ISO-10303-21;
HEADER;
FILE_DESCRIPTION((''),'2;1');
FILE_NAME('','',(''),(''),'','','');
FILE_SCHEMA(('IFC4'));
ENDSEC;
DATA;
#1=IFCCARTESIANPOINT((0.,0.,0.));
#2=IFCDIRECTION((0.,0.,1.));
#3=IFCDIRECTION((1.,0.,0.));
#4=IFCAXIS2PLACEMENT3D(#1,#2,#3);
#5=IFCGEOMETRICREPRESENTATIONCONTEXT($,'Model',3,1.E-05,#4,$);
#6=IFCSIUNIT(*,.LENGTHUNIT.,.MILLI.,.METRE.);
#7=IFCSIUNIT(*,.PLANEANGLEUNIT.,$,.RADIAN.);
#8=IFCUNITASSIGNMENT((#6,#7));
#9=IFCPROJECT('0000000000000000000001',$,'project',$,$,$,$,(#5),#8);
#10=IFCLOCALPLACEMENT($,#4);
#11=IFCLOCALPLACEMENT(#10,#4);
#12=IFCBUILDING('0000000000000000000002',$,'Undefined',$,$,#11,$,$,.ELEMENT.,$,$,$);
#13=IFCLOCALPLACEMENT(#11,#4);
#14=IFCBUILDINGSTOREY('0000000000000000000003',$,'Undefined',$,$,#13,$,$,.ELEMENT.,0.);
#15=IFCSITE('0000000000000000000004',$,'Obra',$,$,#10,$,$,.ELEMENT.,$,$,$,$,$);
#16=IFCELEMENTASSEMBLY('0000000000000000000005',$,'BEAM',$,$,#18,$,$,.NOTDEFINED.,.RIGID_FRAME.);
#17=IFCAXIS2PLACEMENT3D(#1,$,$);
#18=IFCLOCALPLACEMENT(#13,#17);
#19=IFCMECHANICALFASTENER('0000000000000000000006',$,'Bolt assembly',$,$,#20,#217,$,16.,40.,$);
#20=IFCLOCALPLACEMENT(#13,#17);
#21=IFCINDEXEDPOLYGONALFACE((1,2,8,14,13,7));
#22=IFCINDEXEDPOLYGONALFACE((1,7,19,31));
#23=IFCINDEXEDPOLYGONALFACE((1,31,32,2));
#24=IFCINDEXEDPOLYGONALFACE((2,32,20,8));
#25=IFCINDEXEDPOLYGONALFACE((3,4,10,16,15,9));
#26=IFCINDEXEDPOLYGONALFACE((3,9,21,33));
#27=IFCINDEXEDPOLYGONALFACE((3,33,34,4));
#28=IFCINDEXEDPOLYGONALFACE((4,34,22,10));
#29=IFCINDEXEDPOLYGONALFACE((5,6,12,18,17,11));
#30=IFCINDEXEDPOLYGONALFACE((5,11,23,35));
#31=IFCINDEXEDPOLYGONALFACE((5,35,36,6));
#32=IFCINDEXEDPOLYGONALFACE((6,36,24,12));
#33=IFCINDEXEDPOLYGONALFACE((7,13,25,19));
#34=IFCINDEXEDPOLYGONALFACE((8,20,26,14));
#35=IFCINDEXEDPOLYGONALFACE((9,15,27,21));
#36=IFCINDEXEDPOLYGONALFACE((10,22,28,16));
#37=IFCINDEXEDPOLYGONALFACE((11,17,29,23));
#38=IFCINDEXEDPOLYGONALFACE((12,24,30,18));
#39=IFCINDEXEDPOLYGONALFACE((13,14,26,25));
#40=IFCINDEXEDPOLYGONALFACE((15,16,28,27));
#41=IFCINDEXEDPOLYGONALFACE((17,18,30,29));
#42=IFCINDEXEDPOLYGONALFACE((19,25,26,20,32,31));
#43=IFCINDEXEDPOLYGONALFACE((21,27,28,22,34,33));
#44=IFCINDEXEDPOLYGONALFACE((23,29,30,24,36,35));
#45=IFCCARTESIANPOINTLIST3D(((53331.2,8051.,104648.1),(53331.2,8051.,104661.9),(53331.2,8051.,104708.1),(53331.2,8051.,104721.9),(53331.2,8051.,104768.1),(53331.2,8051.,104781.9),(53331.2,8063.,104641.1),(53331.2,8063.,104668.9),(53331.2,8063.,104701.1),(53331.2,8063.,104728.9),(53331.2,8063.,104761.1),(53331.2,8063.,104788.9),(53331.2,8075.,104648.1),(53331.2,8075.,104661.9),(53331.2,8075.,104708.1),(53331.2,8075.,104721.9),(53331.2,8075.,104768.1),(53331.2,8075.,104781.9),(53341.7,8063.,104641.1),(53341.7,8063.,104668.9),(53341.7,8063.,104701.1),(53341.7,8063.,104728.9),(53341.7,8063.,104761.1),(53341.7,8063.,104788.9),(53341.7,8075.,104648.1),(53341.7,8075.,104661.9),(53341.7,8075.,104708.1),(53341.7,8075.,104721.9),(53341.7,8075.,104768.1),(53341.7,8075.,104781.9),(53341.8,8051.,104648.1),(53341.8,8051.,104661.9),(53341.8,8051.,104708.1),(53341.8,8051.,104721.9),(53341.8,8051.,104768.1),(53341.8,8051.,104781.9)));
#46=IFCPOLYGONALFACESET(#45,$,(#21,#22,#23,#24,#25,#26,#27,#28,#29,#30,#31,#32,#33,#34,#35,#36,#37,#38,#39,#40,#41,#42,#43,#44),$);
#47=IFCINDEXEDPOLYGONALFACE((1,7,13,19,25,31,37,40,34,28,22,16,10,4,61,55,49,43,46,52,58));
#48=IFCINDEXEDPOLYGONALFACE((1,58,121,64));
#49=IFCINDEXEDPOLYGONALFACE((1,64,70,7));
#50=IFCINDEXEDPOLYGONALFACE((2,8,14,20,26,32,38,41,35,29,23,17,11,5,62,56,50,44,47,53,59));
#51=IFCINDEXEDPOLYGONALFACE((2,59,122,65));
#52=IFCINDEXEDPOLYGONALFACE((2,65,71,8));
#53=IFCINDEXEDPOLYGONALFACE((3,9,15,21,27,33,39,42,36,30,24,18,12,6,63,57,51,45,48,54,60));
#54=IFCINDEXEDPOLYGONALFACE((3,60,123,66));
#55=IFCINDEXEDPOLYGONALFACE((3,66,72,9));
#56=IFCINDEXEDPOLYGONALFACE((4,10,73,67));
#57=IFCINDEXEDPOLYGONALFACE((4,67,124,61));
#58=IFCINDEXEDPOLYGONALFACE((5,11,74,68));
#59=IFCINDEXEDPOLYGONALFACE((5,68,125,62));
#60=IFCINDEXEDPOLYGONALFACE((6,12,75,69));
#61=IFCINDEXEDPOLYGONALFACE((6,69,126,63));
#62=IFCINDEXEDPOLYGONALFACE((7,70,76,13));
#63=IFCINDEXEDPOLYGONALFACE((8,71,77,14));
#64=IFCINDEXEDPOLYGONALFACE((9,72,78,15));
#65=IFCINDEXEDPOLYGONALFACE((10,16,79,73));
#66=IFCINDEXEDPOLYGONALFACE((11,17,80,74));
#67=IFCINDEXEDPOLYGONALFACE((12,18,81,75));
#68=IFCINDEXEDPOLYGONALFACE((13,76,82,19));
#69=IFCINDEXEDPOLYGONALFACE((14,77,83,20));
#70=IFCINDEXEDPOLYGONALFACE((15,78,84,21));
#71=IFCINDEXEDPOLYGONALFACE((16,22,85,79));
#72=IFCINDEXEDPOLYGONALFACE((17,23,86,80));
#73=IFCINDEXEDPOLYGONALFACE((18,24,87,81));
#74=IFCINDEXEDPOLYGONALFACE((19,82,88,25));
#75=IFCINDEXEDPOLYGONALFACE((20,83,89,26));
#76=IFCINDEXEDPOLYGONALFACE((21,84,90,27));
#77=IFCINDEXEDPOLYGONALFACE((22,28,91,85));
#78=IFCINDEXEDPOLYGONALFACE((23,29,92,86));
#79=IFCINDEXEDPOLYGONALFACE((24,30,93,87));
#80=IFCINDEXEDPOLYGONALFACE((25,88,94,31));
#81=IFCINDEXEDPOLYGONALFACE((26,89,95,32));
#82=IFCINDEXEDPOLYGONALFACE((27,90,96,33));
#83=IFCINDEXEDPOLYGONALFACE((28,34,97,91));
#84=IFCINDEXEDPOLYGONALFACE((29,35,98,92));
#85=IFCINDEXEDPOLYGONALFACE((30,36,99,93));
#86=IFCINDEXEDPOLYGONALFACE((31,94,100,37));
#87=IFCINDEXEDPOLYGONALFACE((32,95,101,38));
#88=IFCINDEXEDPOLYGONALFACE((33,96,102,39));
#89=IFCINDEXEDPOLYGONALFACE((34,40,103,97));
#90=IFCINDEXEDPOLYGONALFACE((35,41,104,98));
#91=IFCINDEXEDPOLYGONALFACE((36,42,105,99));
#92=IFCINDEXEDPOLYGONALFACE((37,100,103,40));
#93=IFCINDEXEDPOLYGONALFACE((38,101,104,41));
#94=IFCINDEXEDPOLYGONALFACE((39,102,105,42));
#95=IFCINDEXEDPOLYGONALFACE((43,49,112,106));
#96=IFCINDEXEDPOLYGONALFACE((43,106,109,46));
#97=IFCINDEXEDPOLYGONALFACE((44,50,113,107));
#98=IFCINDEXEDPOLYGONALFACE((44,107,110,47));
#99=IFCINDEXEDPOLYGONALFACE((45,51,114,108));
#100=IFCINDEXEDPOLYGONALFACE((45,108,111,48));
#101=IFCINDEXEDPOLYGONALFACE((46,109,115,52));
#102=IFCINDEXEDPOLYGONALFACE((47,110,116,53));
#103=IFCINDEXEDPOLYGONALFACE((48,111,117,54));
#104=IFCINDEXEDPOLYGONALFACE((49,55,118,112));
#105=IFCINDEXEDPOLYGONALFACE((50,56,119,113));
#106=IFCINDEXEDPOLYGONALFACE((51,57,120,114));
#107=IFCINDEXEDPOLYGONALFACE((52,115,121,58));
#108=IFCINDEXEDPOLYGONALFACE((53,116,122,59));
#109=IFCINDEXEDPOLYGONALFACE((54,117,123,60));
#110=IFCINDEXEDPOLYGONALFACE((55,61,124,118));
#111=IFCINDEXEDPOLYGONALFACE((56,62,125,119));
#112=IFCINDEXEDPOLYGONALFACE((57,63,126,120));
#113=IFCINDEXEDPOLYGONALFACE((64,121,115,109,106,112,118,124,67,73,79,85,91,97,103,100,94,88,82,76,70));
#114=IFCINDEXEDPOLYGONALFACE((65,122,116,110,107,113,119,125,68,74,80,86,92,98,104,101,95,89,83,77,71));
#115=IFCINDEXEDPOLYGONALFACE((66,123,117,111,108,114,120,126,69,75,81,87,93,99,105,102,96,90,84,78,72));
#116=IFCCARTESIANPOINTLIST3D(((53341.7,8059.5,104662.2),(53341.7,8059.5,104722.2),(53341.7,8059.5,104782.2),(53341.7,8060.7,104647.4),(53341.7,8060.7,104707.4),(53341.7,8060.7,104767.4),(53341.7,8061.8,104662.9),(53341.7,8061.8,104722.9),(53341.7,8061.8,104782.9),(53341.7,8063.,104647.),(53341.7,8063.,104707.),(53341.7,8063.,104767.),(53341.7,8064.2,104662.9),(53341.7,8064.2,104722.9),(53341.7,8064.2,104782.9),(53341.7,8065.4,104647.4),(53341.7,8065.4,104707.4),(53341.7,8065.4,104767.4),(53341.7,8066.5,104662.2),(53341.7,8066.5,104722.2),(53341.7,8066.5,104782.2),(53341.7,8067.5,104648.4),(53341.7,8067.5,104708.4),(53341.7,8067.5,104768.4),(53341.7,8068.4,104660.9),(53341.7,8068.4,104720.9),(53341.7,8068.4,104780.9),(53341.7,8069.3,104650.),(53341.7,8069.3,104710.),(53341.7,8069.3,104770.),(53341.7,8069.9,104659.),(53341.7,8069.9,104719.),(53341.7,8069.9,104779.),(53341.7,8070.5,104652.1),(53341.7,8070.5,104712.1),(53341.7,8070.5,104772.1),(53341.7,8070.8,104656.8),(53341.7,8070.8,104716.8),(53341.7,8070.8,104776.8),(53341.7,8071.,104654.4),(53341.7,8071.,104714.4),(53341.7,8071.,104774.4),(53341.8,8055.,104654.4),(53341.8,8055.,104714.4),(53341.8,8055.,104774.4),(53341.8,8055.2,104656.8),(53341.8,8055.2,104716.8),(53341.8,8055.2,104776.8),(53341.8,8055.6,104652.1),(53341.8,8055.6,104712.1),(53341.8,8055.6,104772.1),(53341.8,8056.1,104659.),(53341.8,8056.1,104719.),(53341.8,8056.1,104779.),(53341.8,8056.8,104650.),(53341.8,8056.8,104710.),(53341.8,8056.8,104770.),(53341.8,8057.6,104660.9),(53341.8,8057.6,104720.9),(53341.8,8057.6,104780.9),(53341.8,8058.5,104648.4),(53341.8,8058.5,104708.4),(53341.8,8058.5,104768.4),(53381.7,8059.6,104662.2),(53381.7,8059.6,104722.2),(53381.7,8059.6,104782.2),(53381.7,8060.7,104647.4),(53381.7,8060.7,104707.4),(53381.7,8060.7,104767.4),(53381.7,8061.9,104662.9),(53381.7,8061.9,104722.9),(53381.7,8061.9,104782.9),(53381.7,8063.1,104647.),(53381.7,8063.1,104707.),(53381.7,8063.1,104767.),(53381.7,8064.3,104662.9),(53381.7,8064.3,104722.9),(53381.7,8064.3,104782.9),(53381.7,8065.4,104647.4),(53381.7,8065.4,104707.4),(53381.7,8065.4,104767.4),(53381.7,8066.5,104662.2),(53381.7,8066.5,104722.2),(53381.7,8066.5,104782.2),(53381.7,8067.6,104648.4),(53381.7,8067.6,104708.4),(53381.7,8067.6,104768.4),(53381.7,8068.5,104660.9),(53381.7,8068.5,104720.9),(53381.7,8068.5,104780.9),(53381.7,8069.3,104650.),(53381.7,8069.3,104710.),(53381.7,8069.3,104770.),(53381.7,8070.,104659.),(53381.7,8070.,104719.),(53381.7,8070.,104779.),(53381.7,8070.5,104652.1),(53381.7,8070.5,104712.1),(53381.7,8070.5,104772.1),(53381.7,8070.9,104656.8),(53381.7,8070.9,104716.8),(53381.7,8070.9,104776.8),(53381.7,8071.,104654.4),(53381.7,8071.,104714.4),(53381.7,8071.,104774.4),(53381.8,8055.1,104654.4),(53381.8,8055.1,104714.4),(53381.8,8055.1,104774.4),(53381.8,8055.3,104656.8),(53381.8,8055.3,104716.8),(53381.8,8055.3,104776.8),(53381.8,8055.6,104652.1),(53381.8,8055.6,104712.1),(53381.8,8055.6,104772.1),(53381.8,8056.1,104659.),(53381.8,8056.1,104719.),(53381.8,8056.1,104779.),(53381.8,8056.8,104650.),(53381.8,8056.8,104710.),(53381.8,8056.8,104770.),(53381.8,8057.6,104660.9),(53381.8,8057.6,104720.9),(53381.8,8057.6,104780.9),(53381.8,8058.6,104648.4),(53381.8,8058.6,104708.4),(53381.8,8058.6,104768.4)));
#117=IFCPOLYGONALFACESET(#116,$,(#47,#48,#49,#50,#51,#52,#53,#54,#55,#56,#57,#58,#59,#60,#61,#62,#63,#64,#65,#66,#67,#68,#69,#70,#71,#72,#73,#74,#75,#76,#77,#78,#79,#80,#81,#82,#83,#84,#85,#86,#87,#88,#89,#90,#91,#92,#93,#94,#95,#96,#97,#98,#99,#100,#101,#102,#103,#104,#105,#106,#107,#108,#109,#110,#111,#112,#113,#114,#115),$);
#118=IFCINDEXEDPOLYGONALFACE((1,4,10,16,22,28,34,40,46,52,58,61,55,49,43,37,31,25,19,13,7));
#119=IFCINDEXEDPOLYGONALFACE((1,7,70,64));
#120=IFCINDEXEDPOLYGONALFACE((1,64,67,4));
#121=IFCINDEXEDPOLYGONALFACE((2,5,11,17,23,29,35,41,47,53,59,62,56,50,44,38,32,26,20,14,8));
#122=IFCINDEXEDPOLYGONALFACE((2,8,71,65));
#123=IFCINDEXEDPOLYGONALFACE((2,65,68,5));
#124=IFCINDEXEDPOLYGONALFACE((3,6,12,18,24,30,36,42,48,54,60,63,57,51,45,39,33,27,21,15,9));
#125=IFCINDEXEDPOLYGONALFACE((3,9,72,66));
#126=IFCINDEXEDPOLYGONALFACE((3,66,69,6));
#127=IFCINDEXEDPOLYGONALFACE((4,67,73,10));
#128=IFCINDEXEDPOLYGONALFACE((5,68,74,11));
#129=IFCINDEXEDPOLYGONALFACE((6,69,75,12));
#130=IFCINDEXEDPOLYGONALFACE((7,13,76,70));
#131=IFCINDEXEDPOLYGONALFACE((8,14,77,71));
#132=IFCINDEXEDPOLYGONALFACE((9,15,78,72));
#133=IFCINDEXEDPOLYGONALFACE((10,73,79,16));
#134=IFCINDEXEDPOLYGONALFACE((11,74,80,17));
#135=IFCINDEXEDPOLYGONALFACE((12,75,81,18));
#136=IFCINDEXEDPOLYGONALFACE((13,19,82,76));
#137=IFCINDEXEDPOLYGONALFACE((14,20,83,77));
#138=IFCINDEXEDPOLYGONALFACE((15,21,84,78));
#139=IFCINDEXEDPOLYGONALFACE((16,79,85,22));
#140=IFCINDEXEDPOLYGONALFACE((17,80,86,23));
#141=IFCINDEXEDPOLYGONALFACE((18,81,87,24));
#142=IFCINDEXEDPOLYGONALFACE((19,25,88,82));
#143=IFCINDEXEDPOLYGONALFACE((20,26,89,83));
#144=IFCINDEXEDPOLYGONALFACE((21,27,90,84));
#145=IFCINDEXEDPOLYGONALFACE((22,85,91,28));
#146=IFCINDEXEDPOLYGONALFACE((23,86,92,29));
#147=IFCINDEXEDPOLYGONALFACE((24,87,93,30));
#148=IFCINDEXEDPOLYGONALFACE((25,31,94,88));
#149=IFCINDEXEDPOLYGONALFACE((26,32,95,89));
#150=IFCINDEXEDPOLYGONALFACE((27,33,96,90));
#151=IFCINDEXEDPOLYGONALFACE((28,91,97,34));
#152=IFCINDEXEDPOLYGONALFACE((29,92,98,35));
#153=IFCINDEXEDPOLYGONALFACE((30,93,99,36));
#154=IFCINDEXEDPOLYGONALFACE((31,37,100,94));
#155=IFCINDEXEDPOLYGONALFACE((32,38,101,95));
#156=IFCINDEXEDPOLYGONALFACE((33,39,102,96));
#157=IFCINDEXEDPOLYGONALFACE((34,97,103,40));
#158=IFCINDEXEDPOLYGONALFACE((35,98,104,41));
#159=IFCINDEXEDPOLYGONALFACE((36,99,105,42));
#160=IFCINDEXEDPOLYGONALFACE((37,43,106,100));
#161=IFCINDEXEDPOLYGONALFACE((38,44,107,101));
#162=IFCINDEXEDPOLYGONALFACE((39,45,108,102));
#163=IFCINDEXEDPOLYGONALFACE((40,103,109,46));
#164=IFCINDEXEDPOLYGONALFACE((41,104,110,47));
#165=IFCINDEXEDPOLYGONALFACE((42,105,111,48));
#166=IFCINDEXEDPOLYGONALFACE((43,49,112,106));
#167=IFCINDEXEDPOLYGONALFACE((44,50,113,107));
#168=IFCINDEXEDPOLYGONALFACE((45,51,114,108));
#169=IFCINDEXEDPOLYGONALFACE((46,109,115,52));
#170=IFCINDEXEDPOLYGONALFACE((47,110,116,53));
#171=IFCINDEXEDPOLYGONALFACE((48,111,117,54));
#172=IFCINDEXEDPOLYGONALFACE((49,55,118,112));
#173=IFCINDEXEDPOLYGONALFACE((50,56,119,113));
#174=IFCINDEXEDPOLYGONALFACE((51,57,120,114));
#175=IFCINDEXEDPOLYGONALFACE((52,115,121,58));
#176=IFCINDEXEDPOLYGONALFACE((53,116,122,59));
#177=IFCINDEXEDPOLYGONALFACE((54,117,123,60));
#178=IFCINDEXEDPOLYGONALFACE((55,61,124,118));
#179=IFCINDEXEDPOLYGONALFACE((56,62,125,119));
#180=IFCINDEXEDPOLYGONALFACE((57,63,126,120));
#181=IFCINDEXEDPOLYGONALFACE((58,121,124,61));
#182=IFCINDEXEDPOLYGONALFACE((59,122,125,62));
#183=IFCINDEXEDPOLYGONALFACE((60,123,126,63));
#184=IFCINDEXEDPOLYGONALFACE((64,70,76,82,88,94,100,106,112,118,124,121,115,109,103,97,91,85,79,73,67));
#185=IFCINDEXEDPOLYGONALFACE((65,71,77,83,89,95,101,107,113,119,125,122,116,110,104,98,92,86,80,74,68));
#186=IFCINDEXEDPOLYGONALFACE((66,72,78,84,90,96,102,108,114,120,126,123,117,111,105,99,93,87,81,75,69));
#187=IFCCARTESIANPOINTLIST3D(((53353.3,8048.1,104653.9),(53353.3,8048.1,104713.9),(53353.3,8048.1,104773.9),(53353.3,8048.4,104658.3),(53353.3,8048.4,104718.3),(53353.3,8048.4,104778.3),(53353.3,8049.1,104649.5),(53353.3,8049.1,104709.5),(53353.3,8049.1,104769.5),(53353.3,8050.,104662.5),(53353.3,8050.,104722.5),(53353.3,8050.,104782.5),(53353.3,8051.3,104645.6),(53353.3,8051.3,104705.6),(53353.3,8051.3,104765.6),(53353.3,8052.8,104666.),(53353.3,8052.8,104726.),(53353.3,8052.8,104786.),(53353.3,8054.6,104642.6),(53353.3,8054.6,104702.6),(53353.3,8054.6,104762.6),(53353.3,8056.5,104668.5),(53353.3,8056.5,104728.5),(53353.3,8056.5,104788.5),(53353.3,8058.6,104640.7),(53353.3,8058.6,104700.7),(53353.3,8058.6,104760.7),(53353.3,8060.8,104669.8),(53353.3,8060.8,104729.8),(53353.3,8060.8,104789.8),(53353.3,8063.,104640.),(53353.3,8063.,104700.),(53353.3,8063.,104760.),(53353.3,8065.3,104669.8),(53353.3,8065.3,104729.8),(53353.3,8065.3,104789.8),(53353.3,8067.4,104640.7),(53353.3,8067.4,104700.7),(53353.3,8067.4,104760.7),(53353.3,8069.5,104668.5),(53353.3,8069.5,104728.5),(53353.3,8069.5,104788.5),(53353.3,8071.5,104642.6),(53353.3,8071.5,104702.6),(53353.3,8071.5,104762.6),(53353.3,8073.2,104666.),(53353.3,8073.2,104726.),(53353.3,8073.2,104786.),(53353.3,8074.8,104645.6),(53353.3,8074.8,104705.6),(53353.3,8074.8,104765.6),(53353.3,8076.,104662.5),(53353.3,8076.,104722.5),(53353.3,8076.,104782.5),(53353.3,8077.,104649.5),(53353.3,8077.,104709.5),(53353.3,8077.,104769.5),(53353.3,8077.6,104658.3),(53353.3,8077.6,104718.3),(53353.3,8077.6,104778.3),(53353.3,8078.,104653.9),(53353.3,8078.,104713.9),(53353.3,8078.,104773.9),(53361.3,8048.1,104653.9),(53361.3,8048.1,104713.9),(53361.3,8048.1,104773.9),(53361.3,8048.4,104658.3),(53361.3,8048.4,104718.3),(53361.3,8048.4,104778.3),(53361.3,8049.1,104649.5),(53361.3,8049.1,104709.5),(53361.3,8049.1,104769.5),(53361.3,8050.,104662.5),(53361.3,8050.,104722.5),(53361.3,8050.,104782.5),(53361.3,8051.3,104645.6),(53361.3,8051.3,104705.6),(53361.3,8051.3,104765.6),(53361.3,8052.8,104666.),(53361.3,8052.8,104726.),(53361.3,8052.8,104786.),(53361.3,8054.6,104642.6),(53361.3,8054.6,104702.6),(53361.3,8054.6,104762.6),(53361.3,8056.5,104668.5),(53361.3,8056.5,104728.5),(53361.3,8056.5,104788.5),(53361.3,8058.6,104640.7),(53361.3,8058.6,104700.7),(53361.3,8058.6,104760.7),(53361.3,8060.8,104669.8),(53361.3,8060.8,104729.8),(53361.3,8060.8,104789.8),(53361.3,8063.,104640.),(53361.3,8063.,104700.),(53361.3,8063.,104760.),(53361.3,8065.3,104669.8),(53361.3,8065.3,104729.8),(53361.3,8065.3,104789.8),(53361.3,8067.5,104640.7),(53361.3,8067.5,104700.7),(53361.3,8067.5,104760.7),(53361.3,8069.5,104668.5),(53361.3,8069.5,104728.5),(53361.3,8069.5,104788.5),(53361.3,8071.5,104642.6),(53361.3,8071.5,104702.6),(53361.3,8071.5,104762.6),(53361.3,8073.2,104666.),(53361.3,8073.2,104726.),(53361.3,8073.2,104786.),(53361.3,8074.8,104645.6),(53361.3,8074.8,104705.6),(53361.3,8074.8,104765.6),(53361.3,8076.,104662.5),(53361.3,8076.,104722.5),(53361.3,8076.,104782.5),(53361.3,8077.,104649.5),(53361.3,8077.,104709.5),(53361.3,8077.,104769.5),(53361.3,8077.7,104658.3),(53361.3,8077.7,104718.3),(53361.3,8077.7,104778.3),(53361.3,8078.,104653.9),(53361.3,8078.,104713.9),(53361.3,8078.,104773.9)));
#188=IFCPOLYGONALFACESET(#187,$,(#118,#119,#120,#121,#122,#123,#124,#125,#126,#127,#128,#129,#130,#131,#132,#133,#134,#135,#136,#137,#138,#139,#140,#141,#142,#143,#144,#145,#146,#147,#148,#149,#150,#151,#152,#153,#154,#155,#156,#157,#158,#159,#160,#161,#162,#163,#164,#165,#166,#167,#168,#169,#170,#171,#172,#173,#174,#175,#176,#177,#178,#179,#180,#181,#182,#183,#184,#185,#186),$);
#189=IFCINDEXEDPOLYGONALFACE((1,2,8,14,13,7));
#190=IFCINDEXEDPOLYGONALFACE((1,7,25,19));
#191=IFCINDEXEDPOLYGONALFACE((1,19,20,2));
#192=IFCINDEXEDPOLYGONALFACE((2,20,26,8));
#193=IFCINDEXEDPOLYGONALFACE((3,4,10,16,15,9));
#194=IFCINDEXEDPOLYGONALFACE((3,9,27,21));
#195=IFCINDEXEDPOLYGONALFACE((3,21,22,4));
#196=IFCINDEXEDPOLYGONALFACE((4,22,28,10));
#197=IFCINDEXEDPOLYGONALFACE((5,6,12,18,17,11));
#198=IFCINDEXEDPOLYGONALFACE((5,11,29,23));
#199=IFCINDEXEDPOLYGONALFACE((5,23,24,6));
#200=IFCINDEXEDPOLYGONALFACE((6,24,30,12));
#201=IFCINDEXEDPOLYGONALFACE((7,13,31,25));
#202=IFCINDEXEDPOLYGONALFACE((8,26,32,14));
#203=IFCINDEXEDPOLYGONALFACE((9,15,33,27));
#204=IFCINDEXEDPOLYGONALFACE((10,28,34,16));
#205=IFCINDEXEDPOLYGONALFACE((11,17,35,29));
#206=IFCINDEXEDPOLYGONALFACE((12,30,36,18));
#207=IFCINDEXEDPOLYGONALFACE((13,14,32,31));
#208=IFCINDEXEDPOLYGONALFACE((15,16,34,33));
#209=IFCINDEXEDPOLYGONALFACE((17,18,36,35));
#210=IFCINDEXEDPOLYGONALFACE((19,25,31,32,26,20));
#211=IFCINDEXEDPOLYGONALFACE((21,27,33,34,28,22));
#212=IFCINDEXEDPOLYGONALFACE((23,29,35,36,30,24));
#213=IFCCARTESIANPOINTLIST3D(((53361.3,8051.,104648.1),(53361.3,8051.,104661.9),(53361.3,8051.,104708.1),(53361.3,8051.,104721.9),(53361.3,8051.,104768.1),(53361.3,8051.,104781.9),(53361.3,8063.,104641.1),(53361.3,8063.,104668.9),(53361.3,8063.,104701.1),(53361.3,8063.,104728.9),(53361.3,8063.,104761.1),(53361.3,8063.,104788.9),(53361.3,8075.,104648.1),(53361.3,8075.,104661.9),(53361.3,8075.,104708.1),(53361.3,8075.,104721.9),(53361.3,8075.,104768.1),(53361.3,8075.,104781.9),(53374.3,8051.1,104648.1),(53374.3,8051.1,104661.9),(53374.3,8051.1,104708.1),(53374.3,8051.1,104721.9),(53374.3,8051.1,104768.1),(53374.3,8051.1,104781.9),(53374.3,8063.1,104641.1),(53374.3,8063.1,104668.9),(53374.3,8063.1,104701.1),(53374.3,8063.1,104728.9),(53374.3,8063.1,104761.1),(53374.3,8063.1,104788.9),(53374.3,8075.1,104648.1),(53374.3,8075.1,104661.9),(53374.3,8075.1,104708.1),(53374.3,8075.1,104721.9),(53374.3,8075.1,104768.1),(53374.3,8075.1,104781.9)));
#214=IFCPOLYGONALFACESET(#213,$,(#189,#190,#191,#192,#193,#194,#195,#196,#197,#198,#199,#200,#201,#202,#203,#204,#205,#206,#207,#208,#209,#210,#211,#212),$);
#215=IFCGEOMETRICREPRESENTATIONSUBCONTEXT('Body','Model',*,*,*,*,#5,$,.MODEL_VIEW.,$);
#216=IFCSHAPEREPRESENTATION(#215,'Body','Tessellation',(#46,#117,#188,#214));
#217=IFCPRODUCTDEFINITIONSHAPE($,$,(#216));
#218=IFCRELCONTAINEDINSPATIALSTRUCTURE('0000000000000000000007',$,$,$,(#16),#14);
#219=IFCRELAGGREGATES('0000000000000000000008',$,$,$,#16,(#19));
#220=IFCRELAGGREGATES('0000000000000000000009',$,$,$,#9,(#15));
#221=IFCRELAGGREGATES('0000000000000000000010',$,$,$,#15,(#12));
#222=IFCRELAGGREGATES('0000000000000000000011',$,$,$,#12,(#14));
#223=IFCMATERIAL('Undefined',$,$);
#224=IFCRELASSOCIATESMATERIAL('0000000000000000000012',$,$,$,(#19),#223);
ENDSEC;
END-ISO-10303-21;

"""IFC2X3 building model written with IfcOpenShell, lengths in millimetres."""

from ifc_helpers import new_model, si_unit, frame, origin_with_axes, origin_2d_with_axis, place, context, subcontext, project, spatial, polyline, circle, outline, extrude, source, transform, mapped, material, element, aggregate, save


model = new_model("IFC2X3")

# Units and contexts
model_context = context("Model", 3, precision=1e-05, world=origin_with_axes())
body_context = subcontext(model_context, "Body", "Model", "MODEL_VIEW")
ifc_project = project(units=[si_unit("LENGTHUNIT", "METRE", prefix="MILLI"), si_unit("PLANEANGLEUNIT", "RADIAN")], contexts=[model_context])

# Site, building, storey
site_placement = place(None, origin_with_axes())
site = spatial("IfcSite", under=ifc_project, at=site_placement, Name="Obra", CompositionType="ELEMENT")
building_placement = place(site_placement, origin_with_axes())
building = spatial("IfcBuilding", under=site, at=building_placement, Name="Undefined", CompositionType="ELEMENT")
storey_placement = place(building_placement, origin_with_axes())
storey = spatial("IfcBuildingStorey", under=building, at=storey_placement, Name="Undefined", CompositionType="ELEMENT", Elevation=0.0)

# Element assembly
ifc_material_1 = material(Name="Undefined")
assembly_1_placement = place(storey_placement, origin_with_axes())
assembly_1 = element("IfcElementAssembly", 1, at=assembly_1_placement, inside=storey, Name="BEAM", AssemblyPlace="NOTDEFINED", PredefinedType="RIGID_FRAME")

# Mechanical fastener
shared_shape_1 = source(origin_with_axes(), body_context, "Body", "SweptSolid", [
    extrude(outline(polyline([(13.9, 0.0), (6.9, 12.0), (-6.9, 12.0), (-13.9, 0.0), (-6.9, -12.0), (6.9, -12.0), (13.9, 0.0)])), frame((0.0, -19.7, 0.0), z_axis=(0.0, 1.0, 0.0), x_axis=(1.0, 0.0, 0.0)), (0.0, 0.0, 1.0), 10.6),
    extrude(circle(Radius=8.0, at=origin_2d_with_axis()), frame((0.0, -9.1, 0.0), z_axis=(0.0, 1.0, 0.0), x_axis=(1.0, 0.0, 0.0)), (0.0, 0.0, 1.0), 40.0),
    extrude(circle(Radius=15.0, at=origin_2d_with_axis()), frame((0.0, 2.5, 0.0), z_axis=(0.0, 1.0, 0.0), x_axis=(1.0, 0.0, 0.0)), (0.0, 0.0, 1.0), 8.0),
    extrude(outline(polyline([(13.9, 0.0), (6.9, 12.0), (-6.9, 12.0), (-13.9, 0.0), (-6.9, -12.0), (6.9, -12.0), (13.9, 0.0)])), frame((0.0, 10.5, 0.0), z_axis=(0.0, 1.0, 0.0), x_axis=(1.0, 0.0, 0.0)), (0.0, 0.0, 1.0), 13.0),
])
mechanical_fastener_1_placement = place(assembly_1_placement, frame((53350.8, 8113.0, 104835.0), z_axis=(0.001508, -0.999999, 0.0), x_axis=(0.0, 0.0, -1.0)))
mechanical_fastener_1 = element("IfcMechanicalFastener", 2, at=mechanical_fastener_1_placement, material=ifc_material_1, Name="Bolt assembly", NominalDiameter=16.0, NominalLength=40.0, context=body_context, shape_type="MappedRepresentation", body=[
    mapped(shared_shape_1, transform((60.0, 0.0, 50.0))),
    mapped(shared_shape_1, transform((120.0, 0.0, 50.0))),
    mapped(shared_shape_1, transform((180.0, 0.0, 50.0))),
])
aggregate(assembly_1, [mechanical_fastener_1])

save(model, "model.ifc")
